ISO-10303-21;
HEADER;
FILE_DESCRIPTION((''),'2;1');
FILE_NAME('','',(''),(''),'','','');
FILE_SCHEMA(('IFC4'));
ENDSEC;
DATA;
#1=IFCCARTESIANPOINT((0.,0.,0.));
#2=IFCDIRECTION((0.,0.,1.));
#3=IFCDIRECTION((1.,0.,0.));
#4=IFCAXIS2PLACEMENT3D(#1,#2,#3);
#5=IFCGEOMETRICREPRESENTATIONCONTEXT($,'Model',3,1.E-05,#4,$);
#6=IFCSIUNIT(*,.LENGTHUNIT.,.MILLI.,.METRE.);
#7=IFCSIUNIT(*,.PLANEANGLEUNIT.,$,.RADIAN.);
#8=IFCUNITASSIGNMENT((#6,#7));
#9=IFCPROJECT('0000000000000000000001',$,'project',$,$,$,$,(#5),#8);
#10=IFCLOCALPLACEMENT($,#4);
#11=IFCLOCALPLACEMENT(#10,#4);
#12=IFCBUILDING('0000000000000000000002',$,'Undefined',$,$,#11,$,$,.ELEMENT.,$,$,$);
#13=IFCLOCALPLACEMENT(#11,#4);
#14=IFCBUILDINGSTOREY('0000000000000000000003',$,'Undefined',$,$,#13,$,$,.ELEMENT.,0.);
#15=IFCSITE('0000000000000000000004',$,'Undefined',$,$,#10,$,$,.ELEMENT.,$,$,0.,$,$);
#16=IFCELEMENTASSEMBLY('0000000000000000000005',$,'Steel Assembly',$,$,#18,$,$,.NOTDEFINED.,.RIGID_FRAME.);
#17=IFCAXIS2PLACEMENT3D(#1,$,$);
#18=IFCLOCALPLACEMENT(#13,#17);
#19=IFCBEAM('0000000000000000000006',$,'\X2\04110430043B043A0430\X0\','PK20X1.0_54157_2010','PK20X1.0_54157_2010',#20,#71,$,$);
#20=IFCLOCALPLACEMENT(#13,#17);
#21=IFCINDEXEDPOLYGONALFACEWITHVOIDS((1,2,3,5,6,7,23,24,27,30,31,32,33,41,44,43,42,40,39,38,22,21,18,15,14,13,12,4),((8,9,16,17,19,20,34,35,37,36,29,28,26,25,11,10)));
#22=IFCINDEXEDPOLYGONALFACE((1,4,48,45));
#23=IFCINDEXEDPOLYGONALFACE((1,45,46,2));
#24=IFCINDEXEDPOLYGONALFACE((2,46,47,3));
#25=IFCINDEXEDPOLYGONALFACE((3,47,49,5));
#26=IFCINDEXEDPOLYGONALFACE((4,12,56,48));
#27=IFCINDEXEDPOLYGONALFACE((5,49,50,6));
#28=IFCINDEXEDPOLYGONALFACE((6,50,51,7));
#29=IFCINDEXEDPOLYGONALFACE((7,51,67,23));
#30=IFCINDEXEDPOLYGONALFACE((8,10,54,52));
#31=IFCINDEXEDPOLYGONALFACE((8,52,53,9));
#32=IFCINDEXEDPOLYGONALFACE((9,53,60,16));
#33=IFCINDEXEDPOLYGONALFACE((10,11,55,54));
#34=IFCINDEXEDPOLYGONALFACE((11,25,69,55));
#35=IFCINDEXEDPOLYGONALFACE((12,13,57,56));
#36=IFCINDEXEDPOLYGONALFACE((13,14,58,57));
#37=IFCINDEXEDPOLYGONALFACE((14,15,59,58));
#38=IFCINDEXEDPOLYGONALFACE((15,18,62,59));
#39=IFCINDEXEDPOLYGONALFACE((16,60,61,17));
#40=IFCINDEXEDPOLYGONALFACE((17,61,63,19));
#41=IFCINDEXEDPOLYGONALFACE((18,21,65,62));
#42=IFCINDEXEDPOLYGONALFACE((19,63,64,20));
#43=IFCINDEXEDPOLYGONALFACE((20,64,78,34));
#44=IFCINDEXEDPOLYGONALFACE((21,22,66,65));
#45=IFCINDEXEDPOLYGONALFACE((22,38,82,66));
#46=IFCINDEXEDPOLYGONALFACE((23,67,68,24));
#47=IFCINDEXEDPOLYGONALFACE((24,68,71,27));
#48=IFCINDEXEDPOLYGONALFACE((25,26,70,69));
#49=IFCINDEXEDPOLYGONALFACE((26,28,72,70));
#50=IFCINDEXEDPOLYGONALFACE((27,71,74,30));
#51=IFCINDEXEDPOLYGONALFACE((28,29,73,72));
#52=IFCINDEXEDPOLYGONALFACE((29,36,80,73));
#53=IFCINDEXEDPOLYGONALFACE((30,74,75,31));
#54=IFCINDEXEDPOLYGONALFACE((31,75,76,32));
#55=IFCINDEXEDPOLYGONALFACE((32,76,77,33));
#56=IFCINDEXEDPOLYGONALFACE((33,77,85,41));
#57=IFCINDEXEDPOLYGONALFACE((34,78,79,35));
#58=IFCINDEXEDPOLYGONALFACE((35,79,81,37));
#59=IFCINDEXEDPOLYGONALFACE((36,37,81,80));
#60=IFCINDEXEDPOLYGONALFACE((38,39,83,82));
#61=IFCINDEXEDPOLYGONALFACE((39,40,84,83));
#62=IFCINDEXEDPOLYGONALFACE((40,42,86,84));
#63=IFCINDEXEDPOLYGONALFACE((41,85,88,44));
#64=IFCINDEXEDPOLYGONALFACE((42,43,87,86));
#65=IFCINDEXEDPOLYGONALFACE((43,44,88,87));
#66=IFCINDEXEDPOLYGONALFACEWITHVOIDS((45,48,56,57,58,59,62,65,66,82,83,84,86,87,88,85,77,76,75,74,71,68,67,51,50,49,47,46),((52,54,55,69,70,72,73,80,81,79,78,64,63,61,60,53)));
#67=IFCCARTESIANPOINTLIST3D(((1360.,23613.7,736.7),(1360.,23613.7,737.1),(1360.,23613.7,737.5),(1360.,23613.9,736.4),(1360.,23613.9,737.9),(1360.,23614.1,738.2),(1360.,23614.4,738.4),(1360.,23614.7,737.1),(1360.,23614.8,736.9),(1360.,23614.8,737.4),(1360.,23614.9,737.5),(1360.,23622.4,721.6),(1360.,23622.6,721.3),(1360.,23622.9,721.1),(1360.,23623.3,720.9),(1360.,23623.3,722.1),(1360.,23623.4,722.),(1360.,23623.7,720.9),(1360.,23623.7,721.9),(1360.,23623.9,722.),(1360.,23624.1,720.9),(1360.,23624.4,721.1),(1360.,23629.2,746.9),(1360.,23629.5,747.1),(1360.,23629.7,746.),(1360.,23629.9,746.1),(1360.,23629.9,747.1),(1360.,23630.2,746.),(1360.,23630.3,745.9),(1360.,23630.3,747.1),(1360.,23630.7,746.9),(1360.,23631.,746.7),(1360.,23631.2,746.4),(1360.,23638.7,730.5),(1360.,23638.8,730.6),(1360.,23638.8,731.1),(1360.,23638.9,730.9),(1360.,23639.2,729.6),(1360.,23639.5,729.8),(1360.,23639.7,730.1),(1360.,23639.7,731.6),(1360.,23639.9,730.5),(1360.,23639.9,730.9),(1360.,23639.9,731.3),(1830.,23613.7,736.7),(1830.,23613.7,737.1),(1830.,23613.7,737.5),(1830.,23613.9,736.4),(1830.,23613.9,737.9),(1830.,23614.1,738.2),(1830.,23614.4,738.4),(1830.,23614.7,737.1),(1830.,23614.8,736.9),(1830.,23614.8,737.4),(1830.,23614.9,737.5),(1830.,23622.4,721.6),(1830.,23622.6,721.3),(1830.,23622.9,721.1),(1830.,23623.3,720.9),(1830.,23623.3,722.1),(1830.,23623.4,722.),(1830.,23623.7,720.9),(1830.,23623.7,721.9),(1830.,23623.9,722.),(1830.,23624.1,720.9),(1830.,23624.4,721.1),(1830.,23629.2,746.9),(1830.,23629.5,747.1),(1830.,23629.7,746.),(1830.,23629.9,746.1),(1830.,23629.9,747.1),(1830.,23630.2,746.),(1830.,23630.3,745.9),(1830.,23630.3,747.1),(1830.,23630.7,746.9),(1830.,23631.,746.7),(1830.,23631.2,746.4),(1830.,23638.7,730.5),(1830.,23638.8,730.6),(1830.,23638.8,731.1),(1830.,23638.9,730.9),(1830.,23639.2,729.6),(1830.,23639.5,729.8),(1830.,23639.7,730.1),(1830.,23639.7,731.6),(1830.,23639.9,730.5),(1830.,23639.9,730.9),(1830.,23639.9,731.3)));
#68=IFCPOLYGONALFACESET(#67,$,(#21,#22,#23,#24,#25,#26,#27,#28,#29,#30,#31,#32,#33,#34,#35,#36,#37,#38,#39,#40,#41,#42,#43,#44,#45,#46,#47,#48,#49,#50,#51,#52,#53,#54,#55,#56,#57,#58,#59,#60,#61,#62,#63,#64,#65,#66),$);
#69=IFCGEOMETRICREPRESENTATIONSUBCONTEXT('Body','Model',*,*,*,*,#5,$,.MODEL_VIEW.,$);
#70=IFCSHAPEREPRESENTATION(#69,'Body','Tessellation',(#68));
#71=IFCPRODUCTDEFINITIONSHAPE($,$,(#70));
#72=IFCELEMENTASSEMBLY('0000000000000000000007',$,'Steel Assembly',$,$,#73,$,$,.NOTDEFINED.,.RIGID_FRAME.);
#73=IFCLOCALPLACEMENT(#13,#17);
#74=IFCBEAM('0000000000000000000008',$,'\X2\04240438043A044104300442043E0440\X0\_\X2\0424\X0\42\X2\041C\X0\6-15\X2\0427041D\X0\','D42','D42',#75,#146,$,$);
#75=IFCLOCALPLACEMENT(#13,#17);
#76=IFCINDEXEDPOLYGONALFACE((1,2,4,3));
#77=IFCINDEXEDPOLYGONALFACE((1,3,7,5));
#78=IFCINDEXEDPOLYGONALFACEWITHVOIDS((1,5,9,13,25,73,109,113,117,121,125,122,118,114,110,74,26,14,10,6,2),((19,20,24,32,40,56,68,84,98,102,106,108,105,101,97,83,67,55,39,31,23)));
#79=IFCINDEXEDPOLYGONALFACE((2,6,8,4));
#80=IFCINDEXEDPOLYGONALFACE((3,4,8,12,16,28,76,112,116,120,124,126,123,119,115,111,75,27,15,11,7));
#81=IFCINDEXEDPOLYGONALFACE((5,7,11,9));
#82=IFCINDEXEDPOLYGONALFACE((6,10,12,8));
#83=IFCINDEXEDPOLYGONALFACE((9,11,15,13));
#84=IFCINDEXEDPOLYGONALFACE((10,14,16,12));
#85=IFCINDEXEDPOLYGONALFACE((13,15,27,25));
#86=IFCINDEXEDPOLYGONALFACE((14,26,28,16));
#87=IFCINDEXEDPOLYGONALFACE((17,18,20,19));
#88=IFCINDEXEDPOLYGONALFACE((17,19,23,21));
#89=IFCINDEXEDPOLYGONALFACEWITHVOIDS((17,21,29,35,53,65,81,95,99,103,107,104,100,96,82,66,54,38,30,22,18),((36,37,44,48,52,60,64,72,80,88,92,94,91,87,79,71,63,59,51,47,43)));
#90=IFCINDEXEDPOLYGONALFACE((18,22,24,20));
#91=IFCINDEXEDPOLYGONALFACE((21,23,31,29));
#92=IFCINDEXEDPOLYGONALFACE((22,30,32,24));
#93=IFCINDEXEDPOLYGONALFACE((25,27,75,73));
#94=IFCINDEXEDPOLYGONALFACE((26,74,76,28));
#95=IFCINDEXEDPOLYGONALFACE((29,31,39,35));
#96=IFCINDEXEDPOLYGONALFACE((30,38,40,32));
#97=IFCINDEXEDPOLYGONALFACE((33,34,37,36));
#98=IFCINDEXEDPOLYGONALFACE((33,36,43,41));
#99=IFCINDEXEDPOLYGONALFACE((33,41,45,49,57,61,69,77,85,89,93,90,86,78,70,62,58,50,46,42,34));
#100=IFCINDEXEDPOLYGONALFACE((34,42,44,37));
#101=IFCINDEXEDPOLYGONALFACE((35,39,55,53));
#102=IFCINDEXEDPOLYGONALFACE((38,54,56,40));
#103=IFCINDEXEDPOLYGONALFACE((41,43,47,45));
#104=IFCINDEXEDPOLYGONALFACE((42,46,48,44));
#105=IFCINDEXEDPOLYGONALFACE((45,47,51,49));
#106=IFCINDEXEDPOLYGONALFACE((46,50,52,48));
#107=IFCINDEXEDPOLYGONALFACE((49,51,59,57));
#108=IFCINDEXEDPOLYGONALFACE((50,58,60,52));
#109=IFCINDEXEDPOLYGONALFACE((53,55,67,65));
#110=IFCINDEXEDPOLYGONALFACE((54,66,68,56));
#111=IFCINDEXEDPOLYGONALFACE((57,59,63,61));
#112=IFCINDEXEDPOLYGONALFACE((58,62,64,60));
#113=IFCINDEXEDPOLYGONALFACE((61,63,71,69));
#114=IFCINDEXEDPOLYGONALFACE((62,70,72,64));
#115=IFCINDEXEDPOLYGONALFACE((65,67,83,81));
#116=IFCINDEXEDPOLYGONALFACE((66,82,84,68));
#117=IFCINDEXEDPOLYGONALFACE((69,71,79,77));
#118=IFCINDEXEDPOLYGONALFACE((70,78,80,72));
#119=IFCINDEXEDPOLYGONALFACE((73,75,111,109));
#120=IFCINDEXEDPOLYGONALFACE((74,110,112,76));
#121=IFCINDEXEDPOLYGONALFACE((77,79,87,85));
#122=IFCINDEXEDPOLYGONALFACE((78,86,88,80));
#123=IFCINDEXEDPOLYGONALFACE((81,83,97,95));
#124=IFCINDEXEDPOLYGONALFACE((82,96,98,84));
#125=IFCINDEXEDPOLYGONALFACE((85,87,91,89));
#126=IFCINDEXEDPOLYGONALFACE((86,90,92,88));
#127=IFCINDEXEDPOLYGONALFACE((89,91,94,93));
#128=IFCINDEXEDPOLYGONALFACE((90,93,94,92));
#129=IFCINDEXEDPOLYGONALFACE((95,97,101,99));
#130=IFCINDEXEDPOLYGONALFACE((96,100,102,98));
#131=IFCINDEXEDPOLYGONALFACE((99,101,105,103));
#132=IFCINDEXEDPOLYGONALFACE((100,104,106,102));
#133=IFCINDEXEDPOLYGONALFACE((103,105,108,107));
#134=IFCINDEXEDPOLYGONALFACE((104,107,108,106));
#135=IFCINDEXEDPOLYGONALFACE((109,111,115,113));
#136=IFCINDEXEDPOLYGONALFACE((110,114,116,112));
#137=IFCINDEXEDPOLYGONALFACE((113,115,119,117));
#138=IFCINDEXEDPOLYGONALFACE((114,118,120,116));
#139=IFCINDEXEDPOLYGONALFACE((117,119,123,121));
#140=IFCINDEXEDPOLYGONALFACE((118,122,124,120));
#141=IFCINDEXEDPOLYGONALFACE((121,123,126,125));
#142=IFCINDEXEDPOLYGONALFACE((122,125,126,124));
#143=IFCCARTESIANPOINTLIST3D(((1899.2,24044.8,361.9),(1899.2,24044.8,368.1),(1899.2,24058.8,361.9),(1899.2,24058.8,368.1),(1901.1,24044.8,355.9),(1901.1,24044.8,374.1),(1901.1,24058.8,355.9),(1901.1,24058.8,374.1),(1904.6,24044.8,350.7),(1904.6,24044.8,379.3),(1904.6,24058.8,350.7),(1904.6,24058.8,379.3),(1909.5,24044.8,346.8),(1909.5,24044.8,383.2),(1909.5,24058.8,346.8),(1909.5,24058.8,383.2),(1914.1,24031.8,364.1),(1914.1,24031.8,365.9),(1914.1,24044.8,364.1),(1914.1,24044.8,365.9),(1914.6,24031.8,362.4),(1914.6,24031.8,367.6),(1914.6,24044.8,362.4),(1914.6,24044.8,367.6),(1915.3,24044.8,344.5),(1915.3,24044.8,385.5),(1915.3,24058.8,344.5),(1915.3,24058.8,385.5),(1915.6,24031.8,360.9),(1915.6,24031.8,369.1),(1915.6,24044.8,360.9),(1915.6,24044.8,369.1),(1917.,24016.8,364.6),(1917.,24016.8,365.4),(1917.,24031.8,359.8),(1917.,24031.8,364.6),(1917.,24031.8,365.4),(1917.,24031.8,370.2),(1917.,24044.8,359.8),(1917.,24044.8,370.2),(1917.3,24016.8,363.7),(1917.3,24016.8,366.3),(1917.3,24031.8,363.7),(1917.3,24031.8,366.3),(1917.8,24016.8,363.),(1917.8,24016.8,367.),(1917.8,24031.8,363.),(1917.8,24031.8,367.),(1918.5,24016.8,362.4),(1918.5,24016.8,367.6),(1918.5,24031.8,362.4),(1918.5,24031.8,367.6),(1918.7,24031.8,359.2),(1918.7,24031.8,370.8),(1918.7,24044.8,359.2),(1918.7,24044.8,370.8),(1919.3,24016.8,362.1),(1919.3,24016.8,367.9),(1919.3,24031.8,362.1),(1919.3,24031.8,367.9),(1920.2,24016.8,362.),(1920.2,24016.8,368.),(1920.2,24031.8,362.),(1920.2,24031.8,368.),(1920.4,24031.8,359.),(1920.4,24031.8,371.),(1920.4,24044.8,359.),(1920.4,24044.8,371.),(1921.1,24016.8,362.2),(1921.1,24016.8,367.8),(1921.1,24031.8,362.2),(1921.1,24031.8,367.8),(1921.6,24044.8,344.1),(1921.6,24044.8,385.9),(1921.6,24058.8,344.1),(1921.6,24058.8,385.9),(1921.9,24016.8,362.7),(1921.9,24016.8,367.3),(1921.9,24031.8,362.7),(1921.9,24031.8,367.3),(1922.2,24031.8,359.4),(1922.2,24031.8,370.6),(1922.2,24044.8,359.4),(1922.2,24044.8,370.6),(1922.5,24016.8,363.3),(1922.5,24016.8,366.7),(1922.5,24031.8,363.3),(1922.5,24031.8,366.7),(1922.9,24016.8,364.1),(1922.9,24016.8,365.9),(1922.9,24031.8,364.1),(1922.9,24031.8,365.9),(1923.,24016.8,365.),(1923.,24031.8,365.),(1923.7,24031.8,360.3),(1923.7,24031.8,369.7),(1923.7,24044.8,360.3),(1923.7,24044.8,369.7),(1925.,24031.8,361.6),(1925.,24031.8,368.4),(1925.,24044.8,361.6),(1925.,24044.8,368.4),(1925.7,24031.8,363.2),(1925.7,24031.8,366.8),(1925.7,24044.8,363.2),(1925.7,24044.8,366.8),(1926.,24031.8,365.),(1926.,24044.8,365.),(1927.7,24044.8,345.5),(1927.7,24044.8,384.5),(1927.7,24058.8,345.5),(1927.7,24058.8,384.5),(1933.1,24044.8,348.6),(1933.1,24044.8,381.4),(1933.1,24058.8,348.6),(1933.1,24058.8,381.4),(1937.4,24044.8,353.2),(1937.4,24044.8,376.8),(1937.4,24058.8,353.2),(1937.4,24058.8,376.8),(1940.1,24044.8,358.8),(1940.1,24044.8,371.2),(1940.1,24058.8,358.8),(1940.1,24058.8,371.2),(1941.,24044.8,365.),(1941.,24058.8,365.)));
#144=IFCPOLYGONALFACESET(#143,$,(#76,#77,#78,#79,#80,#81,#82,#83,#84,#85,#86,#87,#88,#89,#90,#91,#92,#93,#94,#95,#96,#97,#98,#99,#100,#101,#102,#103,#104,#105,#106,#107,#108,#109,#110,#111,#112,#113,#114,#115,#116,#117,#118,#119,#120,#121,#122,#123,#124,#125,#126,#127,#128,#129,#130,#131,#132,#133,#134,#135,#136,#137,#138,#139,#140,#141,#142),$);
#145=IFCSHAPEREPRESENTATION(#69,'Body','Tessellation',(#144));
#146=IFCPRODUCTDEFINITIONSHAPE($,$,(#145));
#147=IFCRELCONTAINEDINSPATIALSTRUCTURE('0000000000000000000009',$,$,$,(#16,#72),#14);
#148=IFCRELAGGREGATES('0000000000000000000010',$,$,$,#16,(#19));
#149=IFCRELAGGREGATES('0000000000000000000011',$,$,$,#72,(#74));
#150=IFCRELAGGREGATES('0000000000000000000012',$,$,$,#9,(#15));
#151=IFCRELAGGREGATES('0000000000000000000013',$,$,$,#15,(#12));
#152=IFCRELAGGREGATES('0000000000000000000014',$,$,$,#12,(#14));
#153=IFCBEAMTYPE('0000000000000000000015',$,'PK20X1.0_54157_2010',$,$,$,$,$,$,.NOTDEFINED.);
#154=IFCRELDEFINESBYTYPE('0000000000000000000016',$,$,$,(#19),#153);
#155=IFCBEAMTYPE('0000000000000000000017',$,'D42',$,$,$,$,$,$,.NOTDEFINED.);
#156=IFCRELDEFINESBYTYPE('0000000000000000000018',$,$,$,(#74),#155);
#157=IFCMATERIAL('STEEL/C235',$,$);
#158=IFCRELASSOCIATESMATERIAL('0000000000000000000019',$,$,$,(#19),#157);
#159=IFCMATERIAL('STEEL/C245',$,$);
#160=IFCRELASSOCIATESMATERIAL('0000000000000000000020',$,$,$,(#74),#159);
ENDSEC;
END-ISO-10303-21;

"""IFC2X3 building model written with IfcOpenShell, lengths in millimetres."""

from ifc_helpers import new_model, si_unit, frame, origin_with_axes, origin_2d_with_axis, place, context, subcontext, project, spatial, hollow_rectangle, circle, extrude, boolean, material, type_object, element, aggregate, save


model = new_model("IFC2X3")

# Units and contexts
model_context = context("Model", 3, precision=1e-05, world=origin_with_axes())
body_context = subcontext(model_context, "Body", "Model", "MODEL_VIEW")
ifc_project = project(units=[si_unit("LENGTHUNIT", "METRE", prefix="MILLI"), si_unit("PLANEANGLEUNIT", "RADIAN")], contexts=[model_context])

# Site, building, storey
site_placement = place(None, origin_with_axes())
site = spatial("IfcSite", under=ifc_project, at=site_placement, Name="Undefined", CompositionType="ELEMENT", RefElevation=0.0)
building_placement = place(site_placement, origin_with_axes())
building = spatial("IfcBuilding", under=site, at=building_placement, Name="Undefined", CompositionType="ELEMENT")
storey_placement = place(building_placement, origin_with_axes())
storey = spatial("IfcBuildingStorey", under=building, at=storey_placement, Name="Undefined", CompositionType="ELEMENT", Elevation=0.0)

# Element assemblies, beams
ifc_material_1 = material(Name="STEEL/C235")
assembly_1_placement = place(storey_placement, origin_with_axes())
assembly_1 = element("IfcElementAssembly", 1, at=assembly_1_placement, inside=storey, Name="Steel Assembly", AssemblyPlace="NOTDEFINED", PredefinedType="RIGID_FRAME")
beam_type_1 = type_object("IfcBeamType", Name="PK20X1.0_54157_2010", PredefinedType="NOTDEFINED")
beam_1_placement = place(assembly_1_placement, frame((1360.0, 23626.8, 734.0), z_axis=(0.0, -0.866025, -0.5), x_axis=(1.0, 0.0, 0.0)))
beam_1 = element("IfcBeam", 2, at=beam_1_placement, type_object=beam_type_1, material=ifc_material_1, Name="Балка", Description="PK20X1.0_54157_2010", ObjectType="PK20X1.0_54157_2010", context=body_context, shape_type="SweptSolid", body=[
    extrude(hollow_rectangle(XDim=20.0, YDim=20.0, WallThickness=1.0, InnerFilletRadius=0.5, OuterFilletRadius=1.5, at=origin_2d_with_axis()), frame((470.0, 0.0, 0.0), z_axis=(-1.0, 0.0, 0.0), x_axis=(0.0, -1.0, 0.0)), (0.0, 0.0, 1.0), 470.0),
])
aggregate(assembly_1, [beam_1])
ifc_material_2 = material(Name="STEEL/C245")
assembly_2_placement = place(storey_placement, origin_with_axes())
assembly_2 = element("IfcElementAssembly", 3, at=assembly_2_placement, inside=storey, Name="Steel Assembly", AssemblyPlace="NOTDEFINED", PredefinedType="RIGID_FRAME")
beam_type_2 = type_object("IfcBeamType", Name="D42", PredefinedType="NOTDEFINED")
beam_2_placement = place(assembly_2_placement, frame((1920.0, 24016.8, 365.0), z_axis=(0.0, 0.0, 1.0), x_axis=(0.0, 1.0, 0.0)))
solid_1 = boolean("DIFFERENCE", extrude(circle(Radius=21.0, at=origin_2d_with_axis()), frame((28.0, 0.0, 0.0), z_axis=(-1.0, 0.0, 0.0), x_axis=(0.0, -1.0, 0.0)), (0.0, 0.0, 1.0), 13.0), extrude(circle(Radius=6.0, at=origin_2d_with_axis()), frame((28.0, 0.0, 0.0), z_axis=(-1.0, 0.0, 0.0), x_axis=(0.0, -1.0, 0.0)), (0.0, 0.0, 1.0), 13.0))
solid_2 = boolean("DIFFERENCE", extrude(circle(Radius=21.0, at=origin_2d_with_axis()), frame((15.0, 0.0, 0.0), z_axis=(-1.0, 0.0, 0.0), x_axis=(0.0, -1.0, 0.0)), (0.0, 0.0, 1.0), 15.0), extrude(circle(Radius=3.0, at=origin_2d_with_axis()), frame((15.0, 0.0, 0.0), z_axis=(-1.0, 0.0, 0.0), x_axis=(0.0, -1.0, 0.0)), (0.0, 0.0, 1.0), 15.0))
beam_2 = element("IfcBeam", 4, at=beam_2_placement, type_object=beam_type_2, material=ifc_material_2, Name="Фиксатор_Ф42М6-15ЧН", Description="D42", ObjectType="D42", context=body_context, shape_type="CSG", body=[
    boolean("DIFFERENCE", boolean("DIFFERENCE", extrude(circle(Radius=21.0, at=origin_2d_with_axis()), frame((42.0, 0.0, 0.0), z_axis=(-1.0, 0.0, 0.0), x_axis=(0.0, -1.0, 0.0)), (0.0, 0.0, 1.0), 42.0), solid_1), solid_2),
])
aggregate(assembly_2, [beam_2])

save(model, "model.ifc")
